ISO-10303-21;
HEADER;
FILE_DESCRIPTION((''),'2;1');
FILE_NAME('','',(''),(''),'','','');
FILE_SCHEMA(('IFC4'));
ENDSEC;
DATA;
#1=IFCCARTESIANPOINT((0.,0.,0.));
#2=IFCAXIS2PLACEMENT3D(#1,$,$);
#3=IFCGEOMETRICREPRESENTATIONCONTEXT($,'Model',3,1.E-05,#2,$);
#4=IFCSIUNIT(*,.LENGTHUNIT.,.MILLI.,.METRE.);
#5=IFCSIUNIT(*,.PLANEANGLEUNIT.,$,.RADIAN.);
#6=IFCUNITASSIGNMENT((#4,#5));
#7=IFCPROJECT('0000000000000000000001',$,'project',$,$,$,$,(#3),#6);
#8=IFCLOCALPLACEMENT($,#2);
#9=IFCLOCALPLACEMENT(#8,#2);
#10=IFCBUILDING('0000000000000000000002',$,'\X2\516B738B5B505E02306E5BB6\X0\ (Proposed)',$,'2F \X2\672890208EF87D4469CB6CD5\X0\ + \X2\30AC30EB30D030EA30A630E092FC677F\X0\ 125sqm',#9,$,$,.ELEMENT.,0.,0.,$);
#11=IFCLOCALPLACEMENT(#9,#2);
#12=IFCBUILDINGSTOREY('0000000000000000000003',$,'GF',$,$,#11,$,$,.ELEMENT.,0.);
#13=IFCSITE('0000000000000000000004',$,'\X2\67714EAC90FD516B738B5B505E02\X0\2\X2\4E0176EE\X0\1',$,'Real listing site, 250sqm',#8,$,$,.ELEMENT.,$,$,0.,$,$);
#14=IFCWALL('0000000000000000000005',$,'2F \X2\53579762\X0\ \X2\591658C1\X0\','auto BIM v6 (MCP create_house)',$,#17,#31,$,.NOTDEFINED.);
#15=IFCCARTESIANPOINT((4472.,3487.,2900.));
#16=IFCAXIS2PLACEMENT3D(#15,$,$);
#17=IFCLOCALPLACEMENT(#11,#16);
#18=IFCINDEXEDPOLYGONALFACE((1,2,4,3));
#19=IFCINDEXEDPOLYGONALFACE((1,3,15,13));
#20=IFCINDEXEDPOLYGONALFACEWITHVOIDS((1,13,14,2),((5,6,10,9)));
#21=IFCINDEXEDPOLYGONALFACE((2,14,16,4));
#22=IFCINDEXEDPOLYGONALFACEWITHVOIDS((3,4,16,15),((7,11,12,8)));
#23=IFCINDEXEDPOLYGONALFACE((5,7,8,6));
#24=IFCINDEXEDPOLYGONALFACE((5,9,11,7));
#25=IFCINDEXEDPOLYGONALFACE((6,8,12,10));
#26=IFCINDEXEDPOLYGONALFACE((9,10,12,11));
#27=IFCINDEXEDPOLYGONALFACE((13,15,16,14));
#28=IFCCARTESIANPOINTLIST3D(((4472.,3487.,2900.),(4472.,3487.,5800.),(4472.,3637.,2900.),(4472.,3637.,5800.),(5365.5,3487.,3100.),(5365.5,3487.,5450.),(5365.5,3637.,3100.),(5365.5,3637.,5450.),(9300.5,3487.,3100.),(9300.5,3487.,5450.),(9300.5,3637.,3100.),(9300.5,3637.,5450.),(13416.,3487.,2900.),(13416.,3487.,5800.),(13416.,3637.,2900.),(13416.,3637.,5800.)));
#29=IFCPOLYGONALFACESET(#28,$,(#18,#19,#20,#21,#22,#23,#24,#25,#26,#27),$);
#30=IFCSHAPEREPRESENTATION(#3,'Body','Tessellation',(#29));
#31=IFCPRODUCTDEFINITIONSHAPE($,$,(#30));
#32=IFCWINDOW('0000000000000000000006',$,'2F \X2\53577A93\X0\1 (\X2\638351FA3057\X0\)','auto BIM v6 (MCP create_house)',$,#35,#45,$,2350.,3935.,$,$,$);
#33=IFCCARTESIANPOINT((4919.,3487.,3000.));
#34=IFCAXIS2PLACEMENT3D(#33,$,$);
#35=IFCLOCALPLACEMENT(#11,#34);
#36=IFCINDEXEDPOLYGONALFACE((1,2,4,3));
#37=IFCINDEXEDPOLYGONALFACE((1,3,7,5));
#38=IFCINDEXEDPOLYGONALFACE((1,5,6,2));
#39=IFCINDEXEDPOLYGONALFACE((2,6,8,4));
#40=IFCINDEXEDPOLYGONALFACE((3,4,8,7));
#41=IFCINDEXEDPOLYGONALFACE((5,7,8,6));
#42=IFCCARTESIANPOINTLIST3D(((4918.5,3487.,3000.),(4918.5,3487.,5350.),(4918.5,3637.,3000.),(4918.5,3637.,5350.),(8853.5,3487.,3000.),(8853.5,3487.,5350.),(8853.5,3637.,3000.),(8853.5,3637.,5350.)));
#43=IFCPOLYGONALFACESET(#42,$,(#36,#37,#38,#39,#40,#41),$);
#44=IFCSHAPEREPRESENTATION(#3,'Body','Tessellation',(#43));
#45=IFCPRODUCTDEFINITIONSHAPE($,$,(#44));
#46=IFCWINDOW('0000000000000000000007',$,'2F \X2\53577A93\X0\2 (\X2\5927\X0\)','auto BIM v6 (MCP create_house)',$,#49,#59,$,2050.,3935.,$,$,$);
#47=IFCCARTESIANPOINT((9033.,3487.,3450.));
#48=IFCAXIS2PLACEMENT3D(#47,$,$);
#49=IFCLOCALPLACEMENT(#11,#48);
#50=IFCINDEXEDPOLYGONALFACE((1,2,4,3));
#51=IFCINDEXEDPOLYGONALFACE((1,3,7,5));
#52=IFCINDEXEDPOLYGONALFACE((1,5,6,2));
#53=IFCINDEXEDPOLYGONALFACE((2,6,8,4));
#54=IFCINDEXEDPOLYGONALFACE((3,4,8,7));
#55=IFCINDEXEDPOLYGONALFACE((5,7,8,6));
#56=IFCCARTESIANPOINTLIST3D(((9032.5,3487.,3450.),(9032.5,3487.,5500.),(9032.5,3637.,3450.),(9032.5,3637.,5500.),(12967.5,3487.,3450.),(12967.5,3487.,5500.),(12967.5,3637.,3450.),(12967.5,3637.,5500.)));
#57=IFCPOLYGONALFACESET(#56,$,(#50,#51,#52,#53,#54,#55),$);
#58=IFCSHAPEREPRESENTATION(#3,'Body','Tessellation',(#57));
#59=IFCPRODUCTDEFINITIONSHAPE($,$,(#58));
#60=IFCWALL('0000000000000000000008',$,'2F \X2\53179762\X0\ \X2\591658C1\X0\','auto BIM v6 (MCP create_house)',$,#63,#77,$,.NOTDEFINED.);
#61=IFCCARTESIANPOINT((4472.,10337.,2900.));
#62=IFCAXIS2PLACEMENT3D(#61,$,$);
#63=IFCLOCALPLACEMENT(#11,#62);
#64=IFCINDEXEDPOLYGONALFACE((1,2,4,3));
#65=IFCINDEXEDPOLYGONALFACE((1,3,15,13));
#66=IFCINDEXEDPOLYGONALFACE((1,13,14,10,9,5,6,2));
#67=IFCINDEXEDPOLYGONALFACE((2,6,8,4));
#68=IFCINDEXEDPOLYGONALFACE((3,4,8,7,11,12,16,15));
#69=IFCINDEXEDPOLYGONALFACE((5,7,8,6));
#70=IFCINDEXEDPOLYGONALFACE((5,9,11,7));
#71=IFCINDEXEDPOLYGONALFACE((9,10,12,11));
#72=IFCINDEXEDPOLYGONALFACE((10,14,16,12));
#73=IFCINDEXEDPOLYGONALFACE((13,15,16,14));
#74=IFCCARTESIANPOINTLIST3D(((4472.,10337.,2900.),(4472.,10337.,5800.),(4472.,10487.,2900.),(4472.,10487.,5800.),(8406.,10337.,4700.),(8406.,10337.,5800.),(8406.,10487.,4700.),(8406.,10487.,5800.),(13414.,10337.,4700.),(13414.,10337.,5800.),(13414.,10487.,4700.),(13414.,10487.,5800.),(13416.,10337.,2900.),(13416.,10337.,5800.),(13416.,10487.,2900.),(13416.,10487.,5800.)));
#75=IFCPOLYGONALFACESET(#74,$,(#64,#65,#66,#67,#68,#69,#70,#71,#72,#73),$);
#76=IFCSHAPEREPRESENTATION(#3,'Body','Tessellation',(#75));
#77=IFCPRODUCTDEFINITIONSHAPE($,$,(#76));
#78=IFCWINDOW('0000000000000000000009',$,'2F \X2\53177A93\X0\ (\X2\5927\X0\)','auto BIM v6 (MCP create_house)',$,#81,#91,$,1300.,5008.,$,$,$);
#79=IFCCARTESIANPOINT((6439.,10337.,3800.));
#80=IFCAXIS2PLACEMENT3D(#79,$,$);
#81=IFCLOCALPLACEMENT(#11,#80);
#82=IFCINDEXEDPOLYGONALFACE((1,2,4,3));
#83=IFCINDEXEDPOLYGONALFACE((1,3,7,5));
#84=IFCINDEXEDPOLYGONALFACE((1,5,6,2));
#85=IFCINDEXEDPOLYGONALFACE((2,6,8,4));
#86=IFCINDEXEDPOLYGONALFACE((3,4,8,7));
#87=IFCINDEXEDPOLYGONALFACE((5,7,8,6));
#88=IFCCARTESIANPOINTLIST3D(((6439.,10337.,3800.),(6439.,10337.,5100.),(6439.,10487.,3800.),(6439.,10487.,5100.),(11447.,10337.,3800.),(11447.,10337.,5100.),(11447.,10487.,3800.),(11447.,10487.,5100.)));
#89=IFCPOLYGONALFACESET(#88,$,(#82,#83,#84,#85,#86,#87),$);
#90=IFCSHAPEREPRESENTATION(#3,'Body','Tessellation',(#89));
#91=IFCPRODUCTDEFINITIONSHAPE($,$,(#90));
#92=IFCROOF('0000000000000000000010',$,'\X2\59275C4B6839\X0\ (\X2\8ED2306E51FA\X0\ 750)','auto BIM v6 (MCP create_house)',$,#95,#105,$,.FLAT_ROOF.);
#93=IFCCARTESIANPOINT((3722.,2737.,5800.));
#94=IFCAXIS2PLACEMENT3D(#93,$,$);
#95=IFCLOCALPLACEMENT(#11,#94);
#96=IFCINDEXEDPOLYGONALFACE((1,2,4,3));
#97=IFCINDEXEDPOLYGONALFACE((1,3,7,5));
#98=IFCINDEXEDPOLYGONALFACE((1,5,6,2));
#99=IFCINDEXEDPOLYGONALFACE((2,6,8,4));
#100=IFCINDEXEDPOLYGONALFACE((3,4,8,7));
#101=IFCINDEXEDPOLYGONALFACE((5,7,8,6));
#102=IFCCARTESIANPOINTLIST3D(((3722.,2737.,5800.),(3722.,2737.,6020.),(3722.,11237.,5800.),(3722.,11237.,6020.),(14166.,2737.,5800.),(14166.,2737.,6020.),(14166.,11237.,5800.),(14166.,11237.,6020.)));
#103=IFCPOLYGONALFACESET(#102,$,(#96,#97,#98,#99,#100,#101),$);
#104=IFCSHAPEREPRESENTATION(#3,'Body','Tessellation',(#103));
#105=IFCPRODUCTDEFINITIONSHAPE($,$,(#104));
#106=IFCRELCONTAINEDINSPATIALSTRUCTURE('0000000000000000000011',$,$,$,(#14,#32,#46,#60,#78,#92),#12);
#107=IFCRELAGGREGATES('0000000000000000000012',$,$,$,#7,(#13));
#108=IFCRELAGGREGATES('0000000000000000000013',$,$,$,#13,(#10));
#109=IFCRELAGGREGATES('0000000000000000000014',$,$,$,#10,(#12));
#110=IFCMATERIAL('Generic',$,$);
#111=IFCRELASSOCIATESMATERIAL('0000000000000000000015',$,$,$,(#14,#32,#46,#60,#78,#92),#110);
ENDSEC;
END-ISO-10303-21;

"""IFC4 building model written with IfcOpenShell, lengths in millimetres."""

from ifc_helpers import new_model, si_unit, frame, frame_2d, origin, place, context, project, spatial, rectangle, extrude, material, element, fill, save


model = new_model("IFC4")

# Units and contexts
model_context = context("Model", 3, precision=1e-05, world=origin())
ifc_project = project(units=[si_unit("LENGTHUNIT", "METRE", prefix="MILLI"), si_unit("PLANEANGLEUNIT", "RADIAN")], contexts=[model_context])

# Site, building, storey
site_placement = place(None, origin())
site = spatial("IfcSite", under=ifc_project, at=site_placement, Name="東京都八王子市2丁目1", ObjectType="Real listing site, 250sqm", CompositionType="ELEMENT", RefElevation=0.0)
building_placement = place(site_placement, origin())
building = spatial("IfcBuilding", under=site, at=building_placement, Name="八王子市の家 (Proposed)", ObjectType="2F 木造軸組構法 + ガルバリウム鋼板 125sqm", CompositionType="ELEMENT", ElevationOfRefHeight=0.0, ElevationOfTerrain=0.0)
storey_placement = place(building_placement, origin())
storey = spatial("IfcBuildingStorey", under=building, at=storey_placement, Name="GF", CompositionType="ELEMENT", Elevation=0.0)

# Shared definitions
ifc_material = material(Name="Generic")

# Wall, openings, windows
wall_1_placement = place(storey_placement, frame((4472.0, 3487.0, 2900.0)))
wall_1 = element("IfcWall", 1, at=wall_1_placement, inside=storey, material=ifc_material, Name="2F 南面 外壁", Description="auto BIM v6 (MCP create_house)", PredefinedType="NOTDEFINED", context=model_context, shape_type="SweptSolid", body=[
    extrude(rectangle(XDim=8944.0, YDim=150.0, at=frame_2d((4472.0, 75.0))), frame((4472.0, 3487.0, 2900.0)), (0.0, 0.0, 1.0), 2900.0),
])
opening_1_placement = place(storey_placement, frame((4919.0, 3487.0, 3000.0)))
opening_1 = element("IfcOpeningElement", 2, at=opening_1_placement, cuts=wall_1, PredefinedType="NOTDEFINED", context=model_context, shape_type="SweptSolid", body=[
    extrude(rectangle(XDim=3935.0, YDim=150.0, at=frame_2d((1967.0, 75.0))), frame((4919.0, 3487.0, 3000.0)), (0.0, 0.0, 1.0), 2350.0),
])
opening_2_placement = place(storey_placement, frame((9033.0, 3487.0, 3450.0)))
opening_2 = element("IfcOpeningElement", 3, at=opening_2_placement, cuts=wall_1, PredefinedType="NOTDEFINED", context=model_context, shape_type="SweptSolid", body=[
    extrude(rectangle(XDim=3935.0, YDim=150.0, at=frame_2d((1967.0, 75.0))), frame((9033.0, 3487.0, 3450.0)), (0.0, 0.0, 1.0), 2050.0),
])
window_1_placement = place(storey_placement, frame((4919.0, 3487.0, 3000.0)))
window_1 = element("IfcWindow", 4, at=window_1_placement, inside=storey, material=ifc_material, Name="2F 南窓1 (掃出し)", Description="auto BIM v6 (MCP create_house)", OverallHeight=2350.0, OverallWidth=3935.0, context=model_context, shape_type="SweptSolid", body=[
    extrude(rectangle(XDim=3935.0, YDim=150.0, at=frame_2d((1967.0, 75.0))), frame((4919.0, 3487.0, 3000.0)), (0.0, 0.0, 1.0), 2350.0),
])
fill(opening_1, window_1)
window_2_placement = place(storey_placement, frame((9033.0, 3487.0, 3450.0)))
window_2 = element("IfcWindow", 5, at=window_2_placement, inside=storey, material=ifc_material, Name="2F 南窓2 (大)", Description="auto BIM v6 (MCP create_house)", OverallHeight=2050.0, OverallWidth=3935.0, context=model_context, shape_type="SweptSolid", body=[
    extrude(rectangle(XDim=3935.0, YDim=150.0, at=frame_2d((1967.0, 75.0))), frame((9033.0, 3487.0, 3450.0)), (0.0, 0.0, 1.0), 2050.0),
])
fill(opening_2, window_2)

# Wall, opening, window
wall_2_placement = place(storey_placement, frame((4472.0, 10337.0, 2900.0)))
wall_2 = element("IfcWall", 6, at=wall_2_placement, inside=storey, material=ifc_material, Name="2F 北面 外壁", Description="auto BIM v6 (MCP create_house)", PredefinedType="NOTDEFINED", context=model_context, shape_type="SweptSolid", body=[
    extrude(rectangle(XDim=8944.0, YDim=150.0, at=frame_2d((4472.0, 75.0))), frame((4472.0, 10337.0, 2900.0)), (0.0, 0.0, 1.0), 2900.0),
])
opening_3_placement = place(storey_placement, frame((6439.0, 10337.0, 3800.0)))
opening_3 = element("IfcOpeningElement", 7, at=opening_3_placement, cuts=wall_2, PredefinedType="NOTDEFINED", context=model_context, shape_type="SweptSolid", body=[
    extrude(rectangle(XDim=5008.0, YDim=150.0, at=frame_2d((2504.0, 75.0))), frame((6439.0, 10337.0, 3800.0)), (0.0, 0.0, 1.0), 1300.0),
])
window_3_placement = place(storey_placement, frame((6439.0, 10337.0, 3800.0)))
window_3 = element("IfcWindow", 8, at=window_3_placement, inside=storey, material=ifc_material, Name="2F 北窓 (大)", Description="auto BIM v6 (MCP create_house)", OverallHeight=1300.0, OverallWidth=5008.0, context=model_context, shape_type="SweptSolid", body=[
    extrude(rectangle(XDim=5008.0, YDim=150.0, at=frame_2d((2504.0, 75.0))), frame((6439.0, 10337.0, 3800.0)), (0.0, 0.0, 1.0), 1300.0),
])
fill(opening_3, window_3)

# Roof
roof_placement = place(storey_placement, frame((3722.0, 2737.0, 5800.0)))
element("IfcRoof", 9, at=roof_placement, inside=storey, material=ifc_material, Name="大屋根 (軒の出 750)", Description="auto BIM v6 (MCP create_house)", PredefinedType="FLAT_ROOF", context=model_context, shape_type="SweptSolid", body=[
    extrude(rectangle(XDim=10444.0, YDim=8500.0, at=frame_2d((5222.0, 4250.0))), frame((3722.0, 2737.0, 5800.0)), (0.0, 0.0, 1.0), 220.0),
])

save(model, "model.ifc")
